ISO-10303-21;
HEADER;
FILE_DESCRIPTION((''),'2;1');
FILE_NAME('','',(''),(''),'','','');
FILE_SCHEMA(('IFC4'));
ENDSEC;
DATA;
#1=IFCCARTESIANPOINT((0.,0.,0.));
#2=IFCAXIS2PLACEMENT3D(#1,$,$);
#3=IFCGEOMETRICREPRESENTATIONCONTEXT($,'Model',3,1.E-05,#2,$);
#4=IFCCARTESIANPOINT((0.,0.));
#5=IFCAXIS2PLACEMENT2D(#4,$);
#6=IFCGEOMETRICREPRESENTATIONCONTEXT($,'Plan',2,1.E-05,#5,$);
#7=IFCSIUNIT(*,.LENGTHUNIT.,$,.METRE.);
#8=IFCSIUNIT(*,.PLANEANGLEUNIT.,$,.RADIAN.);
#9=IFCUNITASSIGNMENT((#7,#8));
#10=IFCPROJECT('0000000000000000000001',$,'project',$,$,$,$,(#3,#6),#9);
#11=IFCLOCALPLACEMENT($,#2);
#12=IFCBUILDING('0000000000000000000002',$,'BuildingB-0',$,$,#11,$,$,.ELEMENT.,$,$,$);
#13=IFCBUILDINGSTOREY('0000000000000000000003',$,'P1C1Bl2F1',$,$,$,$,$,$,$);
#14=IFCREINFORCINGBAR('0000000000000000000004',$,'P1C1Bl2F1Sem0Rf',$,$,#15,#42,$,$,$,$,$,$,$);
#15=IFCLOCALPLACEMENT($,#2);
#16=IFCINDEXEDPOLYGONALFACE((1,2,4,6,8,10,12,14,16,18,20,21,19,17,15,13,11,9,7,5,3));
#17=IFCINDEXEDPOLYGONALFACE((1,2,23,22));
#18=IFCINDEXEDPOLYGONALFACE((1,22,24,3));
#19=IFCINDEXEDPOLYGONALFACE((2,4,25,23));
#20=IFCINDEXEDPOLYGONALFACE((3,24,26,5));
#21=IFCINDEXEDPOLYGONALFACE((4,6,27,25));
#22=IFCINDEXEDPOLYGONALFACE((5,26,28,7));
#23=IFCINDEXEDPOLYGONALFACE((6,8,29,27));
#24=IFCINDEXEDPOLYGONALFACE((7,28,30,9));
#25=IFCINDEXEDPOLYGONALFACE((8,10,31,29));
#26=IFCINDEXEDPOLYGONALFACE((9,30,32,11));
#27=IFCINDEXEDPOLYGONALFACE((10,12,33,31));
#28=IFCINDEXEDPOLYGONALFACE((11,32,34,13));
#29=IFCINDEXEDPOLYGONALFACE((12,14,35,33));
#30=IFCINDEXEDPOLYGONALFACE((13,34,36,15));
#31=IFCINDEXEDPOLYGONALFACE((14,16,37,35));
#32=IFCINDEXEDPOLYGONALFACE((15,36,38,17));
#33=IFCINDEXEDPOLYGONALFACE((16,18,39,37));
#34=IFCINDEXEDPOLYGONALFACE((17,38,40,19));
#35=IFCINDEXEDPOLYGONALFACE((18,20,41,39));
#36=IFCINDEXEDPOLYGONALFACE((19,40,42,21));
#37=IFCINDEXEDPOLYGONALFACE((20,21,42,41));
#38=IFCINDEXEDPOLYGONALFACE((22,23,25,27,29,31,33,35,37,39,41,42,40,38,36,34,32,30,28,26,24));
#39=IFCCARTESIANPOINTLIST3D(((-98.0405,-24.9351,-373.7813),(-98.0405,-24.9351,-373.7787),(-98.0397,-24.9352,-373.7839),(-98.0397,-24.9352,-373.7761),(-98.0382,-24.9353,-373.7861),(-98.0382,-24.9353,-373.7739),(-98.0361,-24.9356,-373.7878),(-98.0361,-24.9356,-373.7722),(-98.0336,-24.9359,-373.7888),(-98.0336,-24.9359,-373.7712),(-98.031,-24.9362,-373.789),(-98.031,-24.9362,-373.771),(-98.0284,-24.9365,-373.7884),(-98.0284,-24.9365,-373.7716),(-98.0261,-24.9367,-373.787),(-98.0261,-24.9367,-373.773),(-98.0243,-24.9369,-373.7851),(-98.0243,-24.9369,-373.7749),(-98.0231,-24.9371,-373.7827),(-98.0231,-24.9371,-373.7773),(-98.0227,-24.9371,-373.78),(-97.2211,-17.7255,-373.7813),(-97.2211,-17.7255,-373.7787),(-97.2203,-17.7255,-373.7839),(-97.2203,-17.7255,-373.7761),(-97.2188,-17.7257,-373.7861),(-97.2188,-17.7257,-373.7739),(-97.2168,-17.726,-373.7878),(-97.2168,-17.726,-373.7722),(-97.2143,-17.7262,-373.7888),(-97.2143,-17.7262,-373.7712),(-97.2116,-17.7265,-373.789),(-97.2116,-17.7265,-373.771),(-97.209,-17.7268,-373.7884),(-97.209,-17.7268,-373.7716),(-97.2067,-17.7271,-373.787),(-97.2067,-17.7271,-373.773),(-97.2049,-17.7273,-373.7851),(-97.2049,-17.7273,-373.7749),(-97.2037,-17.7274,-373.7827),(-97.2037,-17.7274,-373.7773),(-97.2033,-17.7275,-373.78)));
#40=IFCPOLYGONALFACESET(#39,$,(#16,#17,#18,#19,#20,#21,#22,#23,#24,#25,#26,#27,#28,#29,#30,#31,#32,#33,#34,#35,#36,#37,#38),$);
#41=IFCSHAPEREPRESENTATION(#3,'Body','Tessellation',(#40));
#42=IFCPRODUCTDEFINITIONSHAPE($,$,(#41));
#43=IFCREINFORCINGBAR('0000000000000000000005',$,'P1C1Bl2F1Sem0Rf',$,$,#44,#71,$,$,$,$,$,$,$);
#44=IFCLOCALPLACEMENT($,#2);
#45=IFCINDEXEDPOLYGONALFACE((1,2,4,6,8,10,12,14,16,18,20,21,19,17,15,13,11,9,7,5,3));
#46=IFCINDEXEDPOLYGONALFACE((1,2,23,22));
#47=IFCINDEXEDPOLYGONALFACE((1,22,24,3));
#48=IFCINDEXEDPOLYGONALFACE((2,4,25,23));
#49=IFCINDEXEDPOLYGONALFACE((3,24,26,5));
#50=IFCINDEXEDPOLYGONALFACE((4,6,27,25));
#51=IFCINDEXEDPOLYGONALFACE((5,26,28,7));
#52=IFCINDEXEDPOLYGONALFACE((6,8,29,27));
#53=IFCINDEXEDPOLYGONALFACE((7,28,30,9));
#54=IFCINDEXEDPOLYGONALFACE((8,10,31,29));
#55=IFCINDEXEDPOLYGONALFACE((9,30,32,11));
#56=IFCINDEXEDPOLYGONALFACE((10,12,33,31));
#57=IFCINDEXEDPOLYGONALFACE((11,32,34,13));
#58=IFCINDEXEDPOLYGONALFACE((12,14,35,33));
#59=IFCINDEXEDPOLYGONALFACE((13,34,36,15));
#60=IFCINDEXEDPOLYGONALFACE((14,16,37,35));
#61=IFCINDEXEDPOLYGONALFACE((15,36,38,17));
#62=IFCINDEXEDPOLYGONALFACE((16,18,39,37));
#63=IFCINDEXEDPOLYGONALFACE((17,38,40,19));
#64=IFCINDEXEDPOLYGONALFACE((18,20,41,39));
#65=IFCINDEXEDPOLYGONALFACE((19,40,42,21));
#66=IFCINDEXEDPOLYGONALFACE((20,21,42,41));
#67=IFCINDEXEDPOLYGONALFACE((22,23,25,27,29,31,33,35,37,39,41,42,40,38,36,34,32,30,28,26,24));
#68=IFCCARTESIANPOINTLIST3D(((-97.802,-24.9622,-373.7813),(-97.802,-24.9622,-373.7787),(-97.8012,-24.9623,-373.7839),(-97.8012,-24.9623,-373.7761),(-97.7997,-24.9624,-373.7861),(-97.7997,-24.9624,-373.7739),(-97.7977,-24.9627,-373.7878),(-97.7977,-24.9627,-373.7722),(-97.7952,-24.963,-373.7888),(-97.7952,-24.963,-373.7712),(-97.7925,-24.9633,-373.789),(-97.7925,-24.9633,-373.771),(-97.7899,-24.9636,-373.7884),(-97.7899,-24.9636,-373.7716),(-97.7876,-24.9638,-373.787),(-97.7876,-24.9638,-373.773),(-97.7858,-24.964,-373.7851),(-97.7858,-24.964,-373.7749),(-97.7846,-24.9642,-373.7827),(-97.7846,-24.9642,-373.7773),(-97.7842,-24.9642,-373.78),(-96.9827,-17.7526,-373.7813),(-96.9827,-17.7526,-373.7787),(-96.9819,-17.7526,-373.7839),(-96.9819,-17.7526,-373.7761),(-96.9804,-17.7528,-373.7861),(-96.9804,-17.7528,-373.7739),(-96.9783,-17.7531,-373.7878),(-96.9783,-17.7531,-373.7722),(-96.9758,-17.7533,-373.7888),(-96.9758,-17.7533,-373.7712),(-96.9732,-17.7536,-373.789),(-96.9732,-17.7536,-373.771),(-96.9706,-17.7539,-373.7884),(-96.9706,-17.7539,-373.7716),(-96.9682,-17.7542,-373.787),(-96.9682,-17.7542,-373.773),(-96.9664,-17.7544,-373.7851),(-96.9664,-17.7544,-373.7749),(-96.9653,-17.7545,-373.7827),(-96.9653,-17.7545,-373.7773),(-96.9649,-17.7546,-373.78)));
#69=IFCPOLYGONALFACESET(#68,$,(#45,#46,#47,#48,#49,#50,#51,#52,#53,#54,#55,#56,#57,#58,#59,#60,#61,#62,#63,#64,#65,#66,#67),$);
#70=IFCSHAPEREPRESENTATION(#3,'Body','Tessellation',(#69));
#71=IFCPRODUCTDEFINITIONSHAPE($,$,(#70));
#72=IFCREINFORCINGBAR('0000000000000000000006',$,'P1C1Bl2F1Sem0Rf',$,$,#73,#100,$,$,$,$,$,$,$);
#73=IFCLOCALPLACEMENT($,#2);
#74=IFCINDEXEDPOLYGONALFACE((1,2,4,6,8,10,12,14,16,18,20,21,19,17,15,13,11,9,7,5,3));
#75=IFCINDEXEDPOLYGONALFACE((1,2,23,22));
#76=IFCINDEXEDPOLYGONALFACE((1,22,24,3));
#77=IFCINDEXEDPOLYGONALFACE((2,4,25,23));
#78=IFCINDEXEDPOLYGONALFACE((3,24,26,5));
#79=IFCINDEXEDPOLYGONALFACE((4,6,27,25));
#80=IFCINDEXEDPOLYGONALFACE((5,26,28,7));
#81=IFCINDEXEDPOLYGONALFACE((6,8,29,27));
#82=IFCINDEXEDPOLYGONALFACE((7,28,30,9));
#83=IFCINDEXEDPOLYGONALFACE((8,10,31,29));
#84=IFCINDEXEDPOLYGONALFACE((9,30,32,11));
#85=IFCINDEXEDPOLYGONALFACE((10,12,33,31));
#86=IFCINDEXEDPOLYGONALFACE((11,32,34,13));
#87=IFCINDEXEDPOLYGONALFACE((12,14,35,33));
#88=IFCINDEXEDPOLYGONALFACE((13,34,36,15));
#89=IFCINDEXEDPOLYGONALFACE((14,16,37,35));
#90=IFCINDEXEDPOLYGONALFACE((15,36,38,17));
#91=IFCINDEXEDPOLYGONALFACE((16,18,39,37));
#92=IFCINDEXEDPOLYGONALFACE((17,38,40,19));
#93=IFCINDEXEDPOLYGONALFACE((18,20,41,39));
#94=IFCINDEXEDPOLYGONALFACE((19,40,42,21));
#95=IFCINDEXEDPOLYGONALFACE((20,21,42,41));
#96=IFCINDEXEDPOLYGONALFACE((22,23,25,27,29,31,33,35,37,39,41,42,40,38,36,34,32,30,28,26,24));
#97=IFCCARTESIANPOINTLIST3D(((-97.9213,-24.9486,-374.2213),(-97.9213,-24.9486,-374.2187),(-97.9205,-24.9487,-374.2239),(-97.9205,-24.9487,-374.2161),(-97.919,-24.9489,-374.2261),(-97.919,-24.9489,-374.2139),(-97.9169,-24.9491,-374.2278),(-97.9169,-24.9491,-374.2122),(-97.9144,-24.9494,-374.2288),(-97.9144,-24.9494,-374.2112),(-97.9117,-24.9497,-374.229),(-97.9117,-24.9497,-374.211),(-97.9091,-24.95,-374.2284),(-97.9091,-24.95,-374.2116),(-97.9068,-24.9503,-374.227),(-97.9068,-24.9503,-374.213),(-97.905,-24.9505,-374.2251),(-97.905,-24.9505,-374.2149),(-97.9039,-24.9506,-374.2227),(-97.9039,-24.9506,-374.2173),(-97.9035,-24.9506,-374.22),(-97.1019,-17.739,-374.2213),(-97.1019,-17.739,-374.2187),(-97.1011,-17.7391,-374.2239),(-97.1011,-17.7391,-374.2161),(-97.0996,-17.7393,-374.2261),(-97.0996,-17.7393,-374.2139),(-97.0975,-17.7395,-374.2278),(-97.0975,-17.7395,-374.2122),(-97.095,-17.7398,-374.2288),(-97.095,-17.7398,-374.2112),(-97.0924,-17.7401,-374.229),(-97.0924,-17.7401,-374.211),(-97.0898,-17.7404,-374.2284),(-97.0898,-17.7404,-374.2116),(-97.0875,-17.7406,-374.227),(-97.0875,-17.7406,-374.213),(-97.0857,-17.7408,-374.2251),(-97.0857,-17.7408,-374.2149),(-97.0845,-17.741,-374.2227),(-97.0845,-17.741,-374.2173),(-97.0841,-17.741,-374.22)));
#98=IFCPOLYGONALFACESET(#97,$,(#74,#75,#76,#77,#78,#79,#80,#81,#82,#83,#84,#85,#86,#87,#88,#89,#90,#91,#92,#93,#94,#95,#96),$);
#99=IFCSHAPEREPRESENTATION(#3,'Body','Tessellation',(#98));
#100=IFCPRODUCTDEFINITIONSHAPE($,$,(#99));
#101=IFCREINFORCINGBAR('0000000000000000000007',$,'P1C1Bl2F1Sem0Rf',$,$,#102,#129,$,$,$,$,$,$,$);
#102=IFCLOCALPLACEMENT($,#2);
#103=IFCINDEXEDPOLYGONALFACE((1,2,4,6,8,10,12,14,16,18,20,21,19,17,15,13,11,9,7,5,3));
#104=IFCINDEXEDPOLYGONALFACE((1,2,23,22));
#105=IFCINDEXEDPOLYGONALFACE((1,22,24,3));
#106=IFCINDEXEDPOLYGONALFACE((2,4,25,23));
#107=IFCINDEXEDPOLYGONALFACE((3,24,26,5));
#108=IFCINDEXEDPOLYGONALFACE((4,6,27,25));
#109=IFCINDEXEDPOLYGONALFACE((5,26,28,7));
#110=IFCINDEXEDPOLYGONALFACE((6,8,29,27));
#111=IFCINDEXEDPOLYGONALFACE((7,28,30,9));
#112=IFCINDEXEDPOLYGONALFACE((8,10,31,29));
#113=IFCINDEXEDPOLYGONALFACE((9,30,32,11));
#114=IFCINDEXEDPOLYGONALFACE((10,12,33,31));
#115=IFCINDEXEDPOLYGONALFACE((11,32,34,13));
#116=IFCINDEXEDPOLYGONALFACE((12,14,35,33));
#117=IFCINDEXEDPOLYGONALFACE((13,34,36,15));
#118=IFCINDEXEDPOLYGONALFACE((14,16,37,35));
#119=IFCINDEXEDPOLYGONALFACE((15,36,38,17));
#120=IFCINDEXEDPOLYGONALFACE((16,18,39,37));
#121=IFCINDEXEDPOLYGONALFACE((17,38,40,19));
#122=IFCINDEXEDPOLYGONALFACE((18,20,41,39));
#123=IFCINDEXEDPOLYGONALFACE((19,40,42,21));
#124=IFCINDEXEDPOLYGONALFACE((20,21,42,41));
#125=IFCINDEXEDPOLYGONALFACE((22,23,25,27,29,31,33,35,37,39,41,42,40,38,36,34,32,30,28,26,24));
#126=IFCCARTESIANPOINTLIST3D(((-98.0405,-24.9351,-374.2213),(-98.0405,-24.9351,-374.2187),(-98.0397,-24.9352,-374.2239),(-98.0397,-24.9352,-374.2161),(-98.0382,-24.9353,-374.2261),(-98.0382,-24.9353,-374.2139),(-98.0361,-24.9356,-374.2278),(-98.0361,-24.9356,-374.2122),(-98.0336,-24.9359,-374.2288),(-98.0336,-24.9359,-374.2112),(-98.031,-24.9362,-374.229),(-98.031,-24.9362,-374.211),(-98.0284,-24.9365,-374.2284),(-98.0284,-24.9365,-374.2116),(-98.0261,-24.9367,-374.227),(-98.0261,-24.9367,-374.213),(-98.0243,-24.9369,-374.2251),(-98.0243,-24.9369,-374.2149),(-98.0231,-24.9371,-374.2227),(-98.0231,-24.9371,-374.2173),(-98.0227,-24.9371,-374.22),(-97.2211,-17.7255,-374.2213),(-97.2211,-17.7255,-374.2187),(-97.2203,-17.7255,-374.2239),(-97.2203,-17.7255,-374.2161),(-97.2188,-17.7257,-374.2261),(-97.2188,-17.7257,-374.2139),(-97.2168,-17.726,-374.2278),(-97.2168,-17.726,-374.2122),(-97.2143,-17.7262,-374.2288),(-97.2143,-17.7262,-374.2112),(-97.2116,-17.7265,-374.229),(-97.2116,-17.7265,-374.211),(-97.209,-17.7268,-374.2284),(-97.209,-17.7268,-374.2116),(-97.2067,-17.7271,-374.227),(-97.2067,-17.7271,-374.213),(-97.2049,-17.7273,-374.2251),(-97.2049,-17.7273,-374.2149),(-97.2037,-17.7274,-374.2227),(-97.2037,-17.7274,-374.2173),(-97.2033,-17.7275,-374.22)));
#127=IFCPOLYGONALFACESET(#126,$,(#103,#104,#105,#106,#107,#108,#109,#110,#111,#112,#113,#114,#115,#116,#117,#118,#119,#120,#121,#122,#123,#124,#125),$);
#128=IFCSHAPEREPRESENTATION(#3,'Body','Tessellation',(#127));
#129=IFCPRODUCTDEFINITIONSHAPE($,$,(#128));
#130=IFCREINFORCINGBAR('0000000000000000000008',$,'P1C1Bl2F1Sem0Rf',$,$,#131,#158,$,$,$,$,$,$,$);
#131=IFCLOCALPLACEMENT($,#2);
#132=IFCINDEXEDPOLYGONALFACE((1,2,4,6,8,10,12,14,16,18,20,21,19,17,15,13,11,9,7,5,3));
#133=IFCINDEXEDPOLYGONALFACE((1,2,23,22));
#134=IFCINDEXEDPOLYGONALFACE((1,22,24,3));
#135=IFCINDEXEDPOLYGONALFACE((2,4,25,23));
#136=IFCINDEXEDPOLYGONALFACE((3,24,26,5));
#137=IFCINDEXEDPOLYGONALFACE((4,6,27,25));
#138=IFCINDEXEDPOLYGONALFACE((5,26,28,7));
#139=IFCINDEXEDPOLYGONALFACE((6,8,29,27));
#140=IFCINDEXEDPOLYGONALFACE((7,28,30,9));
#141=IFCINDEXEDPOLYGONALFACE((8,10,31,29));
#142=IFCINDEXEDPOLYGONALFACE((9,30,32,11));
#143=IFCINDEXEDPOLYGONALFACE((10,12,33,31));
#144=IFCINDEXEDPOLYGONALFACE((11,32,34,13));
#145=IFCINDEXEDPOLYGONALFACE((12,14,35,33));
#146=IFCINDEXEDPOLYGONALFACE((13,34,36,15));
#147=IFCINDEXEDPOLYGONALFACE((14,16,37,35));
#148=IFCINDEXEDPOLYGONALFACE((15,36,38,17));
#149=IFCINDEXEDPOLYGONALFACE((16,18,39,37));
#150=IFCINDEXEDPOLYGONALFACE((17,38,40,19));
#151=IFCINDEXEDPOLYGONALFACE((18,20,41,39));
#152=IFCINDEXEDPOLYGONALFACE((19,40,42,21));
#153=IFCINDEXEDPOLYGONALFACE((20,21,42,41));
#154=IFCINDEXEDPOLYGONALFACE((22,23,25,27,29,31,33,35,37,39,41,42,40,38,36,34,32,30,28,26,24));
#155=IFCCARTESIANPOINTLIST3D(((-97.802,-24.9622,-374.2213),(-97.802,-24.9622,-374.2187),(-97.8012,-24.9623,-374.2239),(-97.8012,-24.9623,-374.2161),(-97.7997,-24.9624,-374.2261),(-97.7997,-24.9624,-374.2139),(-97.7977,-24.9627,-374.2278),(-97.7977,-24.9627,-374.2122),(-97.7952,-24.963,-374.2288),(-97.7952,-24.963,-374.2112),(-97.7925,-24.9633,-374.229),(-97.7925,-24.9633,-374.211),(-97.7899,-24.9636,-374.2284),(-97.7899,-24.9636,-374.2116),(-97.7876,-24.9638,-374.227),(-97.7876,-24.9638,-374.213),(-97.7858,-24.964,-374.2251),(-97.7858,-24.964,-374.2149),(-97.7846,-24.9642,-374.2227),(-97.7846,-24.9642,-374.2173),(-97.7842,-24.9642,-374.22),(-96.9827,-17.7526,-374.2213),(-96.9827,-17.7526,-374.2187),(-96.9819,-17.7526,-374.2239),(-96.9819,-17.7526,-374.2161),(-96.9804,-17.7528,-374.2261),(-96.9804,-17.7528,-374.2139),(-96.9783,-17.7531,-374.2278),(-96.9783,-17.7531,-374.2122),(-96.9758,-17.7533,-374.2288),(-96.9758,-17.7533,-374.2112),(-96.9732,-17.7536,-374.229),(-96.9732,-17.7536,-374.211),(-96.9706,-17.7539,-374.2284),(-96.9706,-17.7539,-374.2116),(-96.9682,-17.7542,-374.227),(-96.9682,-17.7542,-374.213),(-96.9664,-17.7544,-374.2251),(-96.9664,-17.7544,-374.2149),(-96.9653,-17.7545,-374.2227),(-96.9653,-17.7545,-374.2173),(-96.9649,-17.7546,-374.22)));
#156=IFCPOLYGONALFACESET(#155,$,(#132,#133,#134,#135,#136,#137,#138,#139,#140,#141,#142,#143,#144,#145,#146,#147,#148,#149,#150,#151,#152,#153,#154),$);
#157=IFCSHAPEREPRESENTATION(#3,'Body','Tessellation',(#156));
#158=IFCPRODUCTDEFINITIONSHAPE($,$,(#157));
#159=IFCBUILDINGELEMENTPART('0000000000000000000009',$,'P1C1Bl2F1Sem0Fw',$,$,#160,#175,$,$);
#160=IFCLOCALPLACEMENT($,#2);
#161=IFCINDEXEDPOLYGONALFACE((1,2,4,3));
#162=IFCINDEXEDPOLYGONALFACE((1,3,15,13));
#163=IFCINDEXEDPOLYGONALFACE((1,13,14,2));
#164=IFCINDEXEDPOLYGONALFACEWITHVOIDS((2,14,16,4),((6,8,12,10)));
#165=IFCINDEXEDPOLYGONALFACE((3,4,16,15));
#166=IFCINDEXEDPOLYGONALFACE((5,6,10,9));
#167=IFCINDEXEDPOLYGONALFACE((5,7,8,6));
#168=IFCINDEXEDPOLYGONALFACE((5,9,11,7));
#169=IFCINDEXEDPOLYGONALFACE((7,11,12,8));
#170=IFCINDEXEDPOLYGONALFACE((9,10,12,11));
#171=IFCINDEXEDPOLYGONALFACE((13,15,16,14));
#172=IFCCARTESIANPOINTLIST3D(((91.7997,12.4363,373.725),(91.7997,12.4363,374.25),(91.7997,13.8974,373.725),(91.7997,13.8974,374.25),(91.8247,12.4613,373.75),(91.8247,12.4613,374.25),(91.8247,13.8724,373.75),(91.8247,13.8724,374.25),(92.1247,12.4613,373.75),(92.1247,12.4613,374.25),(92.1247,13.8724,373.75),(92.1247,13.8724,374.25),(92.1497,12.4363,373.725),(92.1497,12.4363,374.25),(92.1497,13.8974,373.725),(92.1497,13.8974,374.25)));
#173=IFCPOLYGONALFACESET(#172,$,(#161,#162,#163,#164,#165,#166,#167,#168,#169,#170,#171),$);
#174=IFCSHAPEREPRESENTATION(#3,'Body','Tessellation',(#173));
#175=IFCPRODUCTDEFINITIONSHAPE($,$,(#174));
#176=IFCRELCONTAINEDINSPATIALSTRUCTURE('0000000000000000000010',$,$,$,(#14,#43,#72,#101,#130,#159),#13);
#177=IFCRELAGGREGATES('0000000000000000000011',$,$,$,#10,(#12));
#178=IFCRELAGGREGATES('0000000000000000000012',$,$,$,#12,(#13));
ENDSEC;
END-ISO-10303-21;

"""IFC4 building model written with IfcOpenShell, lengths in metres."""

from ifc_helpers import new_model, entity, si_unit, origin, origin_2d, place, context, project, spatial, polyline, outline, extrude, element, save


model = new_model("IFC4")

# Units and contexts
model_context = context("Model", 3, precision=1e-05, world=origin())
plan_context = context("Plan", 2, precision=1e-05, world=origin_2d())
ifc_project = project(units=[si_unit("LENGTHUNIT", "METRE"), si_unit("PLANEANGLEUNIT", "RADIAN")], contexts=[model_context, plan_context])

# Building, storey
building_placement = place(None, origin())
building = spatial("IfcBuilding", under=ifc_project, at=building_placement, Name="BuildingB-0", CompositionType="ELEMENT")
storey = spatial("IfcBuildingStorey", under=building, Name="P1C1Bl2F1")

# Reinforcing bars
element("IfcReinforcingBar", 1, inside=storey, Name="P1C1Bl2F1Sem0Rf", context=model_context, shape_type="SweptSolid", body=[
    entity("IfcSurfaceCurveSweptAreaSolid", entity("IfcCircleProfileDef", "AREA", None, None, 0.009), None, entity("IfcPolyline", [entity("IfcCartesianPoint", [97.2123, 17.7265, 373.78]), entity("IfcCartesianPoint", [98.0316, 24.9361, 373.78])]), None, None, entity("IfcPlane", entity("IfcAxis2Placement3D", entity("IfcCartesianPoint", [97.2123, 17.7265, 373.78]), entity("IfcDirection", [0.0, 0.0, 1.0]), entity("IfcDirection", [1.0, 0.0, 0.0])))),
])
element("IfcReinforcingBar", 2, inside=storey, Name="P1C1Bl2F1Sem0Rf", context=model_context, shape_type="SweptSolid", body=[
    entity("IfcSurfaceCurveSweptAreaSolid", entity("IfcCircleProfileDef", "AREA", None, None, 0.009), None, entity("IfcPolyline", [entity("IfcCartesianPoint", [96.9738, 17.7536, 373.78]), entity("IfcCartesianPoint", [97.7932, 24.9632, 373.78])]), None, None, entity("IfcPlane", entity("IfcAxis2Placement3D", entity("IfcCartesianPoint", [96.9738, 17.7536, 373.78]), entity("IfcDirection", [0.0, 0.0, 1.0]), entity("IfcDirection", [1.0, 0.0, 0.0])))),
])
element("IfcReinforcingBar", 3, inside=storey, Name="P1C1Bl2F1Sem0Rf", context=model_context, shape_type="SweptSolid", body=[
    entity("IfcSurfaceCurveSweptAreaSolid", entity("IfcCircleProfileDef", "AREA", None, None, 0.009), None, entity("IfcPolyline", [entity("IfcCartesianPoint", [97.0931, 17.74, 374.22]), entity("IfcCartesianPoint", [97.9124, 24.9496, 374.22])]), None, None, entity("IfcPlane", entity("IfcAxis2Placement3D", entity("IfcCartesianPoint", [97.0931, 17.74, 374.22]), entity("IfcDirection", [0.0, 0.0, 1.0]), entity("IfcDirection", [1.0, 0.0, 0.0])))),
])
element("IfcReinforcingBar", 4, inside=storey, Name="P1C1Bl2F1Sem0Rf", context=model_context, shape_type="SweptSolid", body=[
    entity("IfcSurfaceCurveSweptAreaSolid", entity("IfcCircleProfileDef", "AREA", None, None, 0.009), None, entity("IfcPolyline", [entity("IfcCartesianPoint", [97.2123, 17.7265, 374.22]), entity("IfcCartesianPoint", [98.0316, 24.9361, 374.22])]), None, None, entity("IfcPlane", entity("IfcAxis2Placement3D", entity("IfcCartesianPoint", [97.2123, 17.7265, 374.22]), entity("IfcDirection", [0.0, 0.0, 1.0]), entity("IfcDirection", [1.0, 0.0, 0.0])))),
])
element("IfcReinforcingBar", 5, inside=storey, Name="P1C1Bl2F1Sem0Rf", context=model_context, shape_type="SweptSolid", body=[
    entity("IfcSurfaceCurveSweptAreaSolid", entity("IfcCircleProfileDef", "AREA", None, None, 0.009), None, entity("IfcPolyline", [entity("IfcCartesianPoint", [96.9738, 17.7536, 374.22]), entity("IfcCartesianPoint", [97.7932, 24.9632, 374.22])]), None, None, entity("IfcPlane", entity("IfcAxis2Placement3D", entity("IfcCartesianPoint", [96.9738, 17.7536, 374.22]), entity("IfcDirection", [0.0, 0.0, 1.0]), entity("IfcDirection", [1.0, 0.0, 0.0])))),
])

# Building element part, opening
building_element_part_1 = element("IfcBuildingElementPart", 6, inside=storey, Name="P1C1Bl2F1Sem0Fw", context=model_context, shape_type="SweptSolid", body=[
    extrude(outline(polyline([(92.1497, 12.4363, 373.725), (91.7997, 12.4363, 373.725), (91.7997, 13.8974, 373.725), (92.1497, 13.8974, 373.725), (92.1497, 12.4363, 373.725)])), None, (0.0, 0.0, 1.0), 0.525),
])
element("IfcOpeningElement", 7, inside=storey, cuts=building_element_part_1, context=model_context, shape_type="SweptSolid", body=[
    extrude(outline(polyline([(92.1247, 12.4613, 373.75), (91.8247, 12.4613, 373.75), (91.8247, 13.8724, 373.75), (92.1247, 13.8724, 373.75), (92.1247, 12.4613, 373.75)])), None, (0.0, 0.0, 1.0), 0.5),
])

save(model, "model.ifc")
